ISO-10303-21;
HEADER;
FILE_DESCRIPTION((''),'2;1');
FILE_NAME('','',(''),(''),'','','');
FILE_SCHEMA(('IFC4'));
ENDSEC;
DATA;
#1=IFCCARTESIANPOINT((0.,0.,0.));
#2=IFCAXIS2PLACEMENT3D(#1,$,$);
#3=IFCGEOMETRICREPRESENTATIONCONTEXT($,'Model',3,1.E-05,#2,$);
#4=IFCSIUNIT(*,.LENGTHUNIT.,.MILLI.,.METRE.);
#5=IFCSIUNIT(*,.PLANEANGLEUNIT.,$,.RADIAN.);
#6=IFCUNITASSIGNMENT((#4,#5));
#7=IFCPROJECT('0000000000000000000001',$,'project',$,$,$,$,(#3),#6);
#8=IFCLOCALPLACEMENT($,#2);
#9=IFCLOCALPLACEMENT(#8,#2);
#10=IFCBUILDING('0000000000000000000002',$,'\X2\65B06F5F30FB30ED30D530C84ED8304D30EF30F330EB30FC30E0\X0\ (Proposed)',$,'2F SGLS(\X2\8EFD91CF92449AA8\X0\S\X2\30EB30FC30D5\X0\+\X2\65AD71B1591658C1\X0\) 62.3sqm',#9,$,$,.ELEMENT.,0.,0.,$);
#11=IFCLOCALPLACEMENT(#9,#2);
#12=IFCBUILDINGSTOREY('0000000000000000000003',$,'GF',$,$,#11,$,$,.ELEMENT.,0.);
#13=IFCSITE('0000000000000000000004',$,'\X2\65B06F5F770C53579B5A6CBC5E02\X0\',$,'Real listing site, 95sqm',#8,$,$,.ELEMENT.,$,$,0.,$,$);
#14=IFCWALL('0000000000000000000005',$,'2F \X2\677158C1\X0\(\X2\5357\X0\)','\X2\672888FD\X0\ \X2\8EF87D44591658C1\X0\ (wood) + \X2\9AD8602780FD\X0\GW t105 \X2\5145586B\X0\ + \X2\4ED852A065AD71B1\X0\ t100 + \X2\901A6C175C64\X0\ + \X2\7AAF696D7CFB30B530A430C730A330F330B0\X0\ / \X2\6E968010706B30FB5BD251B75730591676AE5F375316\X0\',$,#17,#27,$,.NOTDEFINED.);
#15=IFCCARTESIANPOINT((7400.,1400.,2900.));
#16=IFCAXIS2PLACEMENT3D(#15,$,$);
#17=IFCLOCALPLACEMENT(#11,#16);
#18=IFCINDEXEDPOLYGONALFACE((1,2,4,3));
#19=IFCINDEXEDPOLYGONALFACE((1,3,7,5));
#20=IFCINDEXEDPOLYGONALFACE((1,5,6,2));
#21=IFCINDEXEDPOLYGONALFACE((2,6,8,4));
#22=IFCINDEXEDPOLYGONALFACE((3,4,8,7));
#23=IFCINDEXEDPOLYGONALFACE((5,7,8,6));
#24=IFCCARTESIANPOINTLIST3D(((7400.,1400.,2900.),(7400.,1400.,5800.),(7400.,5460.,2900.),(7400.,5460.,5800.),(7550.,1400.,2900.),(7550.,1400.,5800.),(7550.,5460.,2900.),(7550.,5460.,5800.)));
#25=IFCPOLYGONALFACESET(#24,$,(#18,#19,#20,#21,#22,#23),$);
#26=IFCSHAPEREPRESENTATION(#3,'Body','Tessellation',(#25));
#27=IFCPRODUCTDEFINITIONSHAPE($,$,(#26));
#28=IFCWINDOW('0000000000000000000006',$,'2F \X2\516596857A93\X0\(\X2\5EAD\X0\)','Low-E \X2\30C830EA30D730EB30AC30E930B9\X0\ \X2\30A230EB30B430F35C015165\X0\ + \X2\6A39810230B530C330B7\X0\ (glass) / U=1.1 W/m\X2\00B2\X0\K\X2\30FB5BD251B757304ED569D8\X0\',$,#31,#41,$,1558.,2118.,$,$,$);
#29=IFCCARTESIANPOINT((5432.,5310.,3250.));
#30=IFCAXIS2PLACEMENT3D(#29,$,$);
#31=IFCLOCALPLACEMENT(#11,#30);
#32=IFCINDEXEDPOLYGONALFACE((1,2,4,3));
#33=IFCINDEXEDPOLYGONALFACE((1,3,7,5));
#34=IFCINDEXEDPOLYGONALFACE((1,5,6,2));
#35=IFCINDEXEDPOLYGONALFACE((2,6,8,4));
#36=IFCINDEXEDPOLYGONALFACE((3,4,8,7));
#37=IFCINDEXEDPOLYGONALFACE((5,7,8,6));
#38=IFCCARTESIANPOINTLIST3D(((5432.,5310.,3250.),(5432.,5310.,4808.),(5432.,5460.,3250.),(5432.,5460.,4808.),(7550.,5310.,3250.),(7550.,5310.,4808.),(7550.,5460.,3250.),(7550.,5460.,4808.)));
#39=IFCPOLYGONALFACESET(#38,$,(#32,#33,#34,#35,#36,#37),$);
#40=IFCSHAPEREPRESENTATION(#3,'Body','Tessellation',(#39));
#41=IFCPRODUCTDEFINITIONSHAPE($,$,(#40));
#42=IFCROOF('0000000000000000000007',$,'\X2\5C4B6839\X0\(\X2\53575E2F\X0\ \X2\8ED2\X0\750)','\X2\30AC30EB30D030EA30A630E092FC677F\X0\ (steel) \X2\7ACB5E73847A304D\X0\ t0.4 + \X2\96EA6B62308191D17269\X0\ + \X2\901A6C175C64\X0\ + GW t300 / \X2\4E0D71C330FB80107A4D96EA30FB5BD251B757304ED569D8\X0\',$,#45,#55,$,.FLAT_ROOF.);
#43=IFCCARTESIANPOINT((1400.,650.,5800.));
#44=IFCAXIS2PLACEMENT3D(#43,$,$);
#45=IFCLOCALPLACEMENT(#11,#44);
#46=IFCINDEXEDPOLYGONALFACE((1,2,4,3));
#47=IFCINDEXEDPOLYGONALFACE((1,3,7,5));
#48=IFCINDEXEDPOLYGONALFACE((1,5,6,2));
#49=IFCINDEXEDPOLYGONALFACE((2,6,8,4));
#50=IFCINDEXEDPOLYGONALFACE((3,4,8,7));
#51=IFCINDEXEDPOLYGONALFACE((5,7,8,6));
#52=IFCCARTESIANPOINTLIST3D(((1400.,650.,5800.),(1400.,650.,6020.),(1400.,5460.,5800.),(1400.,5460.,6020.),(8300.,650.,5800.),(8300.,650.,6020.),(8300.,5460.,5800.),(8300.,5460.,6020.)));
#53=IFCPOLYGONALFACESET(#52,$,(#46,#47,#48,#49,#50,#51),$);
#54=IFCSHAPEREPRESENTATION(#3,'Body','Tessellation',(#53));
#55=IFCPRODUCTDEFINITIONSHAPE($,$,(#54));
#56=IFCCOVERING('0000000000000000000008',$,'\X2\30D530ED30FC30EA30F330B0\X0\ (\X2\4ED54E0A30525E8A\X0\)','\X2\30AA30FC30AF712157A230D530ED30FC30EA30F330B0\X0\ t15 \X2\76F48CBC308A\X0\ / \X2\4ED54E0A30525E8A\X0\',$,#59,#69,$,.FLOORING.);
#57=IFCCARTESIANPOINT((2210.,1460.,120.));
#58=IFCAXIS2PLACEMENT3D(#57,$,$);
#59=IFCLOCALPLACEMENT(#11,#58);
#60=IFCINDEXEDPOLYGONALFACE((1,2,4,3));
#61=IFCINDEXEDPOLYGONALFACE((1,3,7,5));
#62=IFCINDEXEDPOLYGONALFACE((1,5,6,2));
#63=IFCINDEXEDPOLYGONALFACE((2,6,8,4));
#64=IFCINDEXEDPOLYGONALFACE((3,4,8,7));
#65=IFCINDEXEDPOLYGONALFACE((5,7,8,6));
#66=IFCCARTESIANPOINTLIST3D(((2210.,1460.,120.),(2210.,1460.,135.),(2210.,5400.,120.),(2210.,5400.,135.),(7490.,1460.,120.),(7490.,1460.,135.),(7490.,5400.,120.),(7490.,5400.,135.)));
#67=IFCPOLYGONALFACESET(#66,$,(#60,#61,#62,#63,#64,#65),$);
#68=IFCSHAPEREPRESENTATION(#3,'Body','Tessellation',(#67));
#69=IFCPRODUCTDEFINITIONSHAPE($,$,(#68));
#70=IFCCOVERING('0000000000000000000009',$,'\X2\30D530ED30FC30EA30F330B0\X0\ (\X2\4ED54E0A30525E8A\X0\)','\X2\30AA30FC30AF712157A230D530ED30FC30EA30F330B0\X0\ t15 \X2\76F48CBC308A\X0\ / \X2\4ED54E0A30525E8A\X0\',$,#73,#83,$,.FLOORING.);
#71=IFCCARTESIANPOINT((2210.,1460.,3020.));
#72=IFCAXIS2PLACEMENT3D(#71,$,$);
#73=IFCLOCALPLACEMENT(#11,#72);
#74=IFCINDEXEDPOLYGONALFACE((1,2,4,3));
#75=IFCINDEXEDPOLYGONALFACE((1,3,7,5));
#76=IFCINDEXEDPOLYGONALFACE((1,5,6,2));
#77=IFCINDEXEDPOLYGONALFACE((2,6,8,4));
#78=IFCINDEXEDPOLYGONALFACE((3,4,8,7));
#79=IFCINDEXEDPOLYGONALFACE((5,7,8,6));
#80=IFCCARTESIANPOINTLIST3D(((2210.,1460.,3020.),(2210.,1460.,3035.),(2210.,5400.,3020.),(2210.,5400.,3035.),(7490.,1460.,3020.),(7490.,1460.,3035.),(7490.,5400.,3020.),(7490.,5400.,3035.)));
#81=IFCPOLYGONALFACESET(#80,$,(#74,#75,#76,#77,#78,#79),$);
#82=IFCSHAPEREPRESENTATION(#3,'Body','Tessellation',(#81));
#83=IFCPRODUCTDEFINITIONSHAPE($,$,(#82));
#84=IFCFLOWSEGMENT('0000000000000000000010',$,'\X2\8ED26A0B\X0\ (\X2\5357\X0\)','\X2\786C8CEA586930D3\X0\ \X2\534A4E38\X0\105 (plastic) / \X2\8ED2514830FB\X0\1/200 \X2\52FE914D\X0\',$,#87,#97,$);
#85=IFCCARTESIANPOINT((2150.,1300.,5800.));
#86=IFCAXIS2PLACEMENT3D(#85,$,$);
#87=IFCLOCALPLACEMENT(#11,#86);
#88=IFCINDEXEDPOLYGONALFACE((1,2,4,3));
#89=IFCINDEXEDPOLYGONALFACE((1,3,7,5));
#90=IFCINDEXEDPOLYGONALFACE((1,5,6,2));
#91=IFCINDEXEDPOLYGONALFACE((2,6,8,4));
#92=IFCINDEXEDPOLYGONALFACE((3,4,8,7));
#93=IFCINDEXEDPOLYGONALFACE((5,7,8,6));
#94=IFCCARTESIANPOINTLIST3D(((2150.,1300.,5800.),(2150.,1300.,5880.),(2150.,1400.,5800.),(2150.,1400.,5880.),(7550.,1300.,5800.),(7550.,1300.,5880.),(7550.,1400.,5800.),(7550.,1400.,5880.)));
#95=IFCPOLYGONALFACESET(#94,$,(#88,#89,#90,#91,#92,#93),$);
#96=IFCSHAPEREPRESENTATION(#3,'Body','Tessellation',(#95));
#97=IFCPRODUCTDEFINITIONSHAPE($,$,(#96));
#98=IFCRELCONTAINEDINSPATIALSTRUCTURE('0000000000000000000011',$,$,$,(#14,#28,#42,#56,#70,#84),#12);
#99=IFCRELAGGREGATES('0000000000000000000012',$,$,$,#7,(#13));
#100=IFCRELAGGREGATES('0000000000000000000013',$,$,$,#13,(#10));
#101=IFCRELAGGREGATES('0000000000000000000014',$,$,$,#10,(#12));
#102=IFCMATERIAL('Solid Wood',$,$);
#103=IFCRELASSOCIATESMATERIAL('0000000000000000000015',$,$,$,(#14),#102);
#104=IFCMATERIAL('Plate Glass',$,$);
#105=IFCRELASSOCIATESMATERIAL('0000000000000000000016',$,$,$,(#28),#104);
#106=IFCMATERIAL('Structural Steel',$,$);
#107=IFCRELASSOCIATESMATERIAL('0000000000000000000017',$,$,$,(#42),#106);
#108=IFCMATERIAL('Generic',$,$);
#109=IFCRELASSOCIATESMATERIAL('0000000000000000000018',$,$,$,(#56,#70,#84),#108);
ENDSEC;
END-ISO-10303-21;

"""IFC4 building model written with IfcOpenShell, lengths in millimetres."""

from ifc_helpers import new_model, si_unit, frame, frame_2d, origin, place, context, project, spatial, rectangle, extrude, material, element, fill, save


model = new_model("IFC4")

# Units and contexts
model_context = context("Model", 3, precision=1e-05, world=origin())
ifc_project = project(units=[si_unit("LENGTHUNIT", "METRE", prefix="MILLI"), si_unit("PLANEANGLEUNIT", "RADIAN")], contexts=[model_context])

# Site, building, storey
site_placement = place(None, origin())
site = spatial("IfcSite", under=ifc_project, at=site_placement, Name="新潟県南魚沼市", ObjectType="Real listing site, 95sqm", CompositionType="ELEMENT", RefElevation=0.0)
building_placement = place(site_placement, origin())
building = spatial("IfcBuilding", under=site, at=building_placement, Name="新潟・ロフト付きワンルーム (Proposed)", ObjectType="2F SGLS(軽量鉄骨Sルーフ+断熱外壁) 62.3sqm", CompositionType="ELEMENT", ElevationOfRefHeight=0.0, ElevationOfTerrain=0.0)
storey_placement = place(building_placement, origin())
storey = spatial("IfcBuildingStorey", under=building, at=storey_placement, Name="GF", CompositionType="ELEMENT", Elevation=0.0)

# Shared definitions
ifc_material_1 = material(Name="Solid Wood")

# Shared definitions
ifc_material_2 = material(Name="Plate Glass")

# Wall, opening, window
wall_1_placement = place(storey_placement, frame((7400.0, 1400.0, 2900.0)))
wall_1 = element("IfcWall", 1, at=wall_1_placement, inside=storey, material=ifc_material_1, Name="2F 東壁(南)", Description="木製 軸組外壁 (wood) + 高性能GW t105 充填 + 付加断熱 t100 + 通気層 + 窯業系サイディング / 準耐火・寒冷地外皮強化", PredefinedType="NOTDEFINED", context=model_context, shape_type="SweptSolid", body=[
    extrude(rectangle(XDim=150.0, YDim=4060.0, at=frame_2d((75.0, 2030.0))), frame((7400.0, 1400.0, 2900.0)), (0.0, 0.0, 1.0), 2900.0),
])
opening_1_placement = place(storey_placement, frame((5432.0, 5310.0, 3250.0)))
opening_1 = element("IfcOpeningElement", 2, at=opening_1_placement, cuts=wall_1, PredefinedType="NOTDEFINED", context=model_context, shape_type="SweptSolid", body=[
    extrude(rectangle(XDim=2118.0, YDim=150.0, at=frame_2d((1059.0, 75.0))), frame((5432.0, 5310.0, 3250.0)), (0.0, 0.0, 1.0), 1558.0),
])
window_1_placement = place(storey_placement, frame((5432.0, 5310.0, 3250.0)))
window_1 = element("IfcWindow", 3, at=window_1_placement, inside=storey, material=ifc_material_2, Name="2F 入隅窓(庭)", Description="Low-E トリプルガラス アルゴン封入 + 樹脂サッシ (glass) / U=1.1 W/m²K・寒冷地仕様", OverallHeight=1558.0, OverallWidth=2118.0, context=model_context, shape_type="SweptSolid", body=[
    extrude(rectangle(XDim=2118.0, YDim=150.0, at=frame_2d((1059.0, 75.0))), frame((5432.0, 5310.0, 3250.0)), (0.0, 0.0, 1.0), 1558.0),
])
fill(opening_1, window_1)

# Roof
ifc_material_3 = material(Name="Structural Steel")
for number, where, name in (
    (4, (1400.0, 650.0, 5800.0), "屋根(南帯 軒750)"),
):
    element("IfcRoof", number, at=place(storey_placement, frame(where)), inside=storey, material=ifc_material_3, Name=name, Description="ガルバリウム鋼板 (steel) 立平葺き t0.4 + 雪止め金物 + 通気層 + GW t300 / 不燃・耐積雪・寒冷地仕様", PredefinedType="FLAT_ROOF", context=model_context, shape_type="SweptSolid", body=[
        extrude(rectangle(XDim=6900.0, YDim=4810.0, at=frame_2d((3450.0, 2405.0))), frame((1400.0, 650.0, 5800.0)), (0.0, 0.0, 1.0), 220.0),
    ])

# Coverings
ifc_material_4 = material(Name="Generic")
covering_1_placement = place(storey_placement, frame((2210.0, 1460.0, 120.0)))
element("IfcCovering", 5, at=covering_1_placement, inside=storey, material=ifc_material_4, Name="フローリング (仕上げ床)", Description="オーク無垢フローリング t15 直貼り / 仕上げ床", PredefinedType="FLOORING", context=model_context, shape_type="SweptSolid", body=[
    extrude(rectangle(XDim=5280.0, YDim=3940.0, at=frame_2d((2640.0, 1970.0))), frame((2210.0, 1460.0, 120.0)), (0.0, 0.0, 1.0), 15.0),
])
covering_2_placement = place(storey_placement, frame((2210.0, 1460.0, 3020.0)))
element("IfcCovering", 6, at=covering_2_placement, inside=storey, material=ifc_material_4, Name="フローリング (仕上げ床)", Description="オーク無垢フローリング t15 直貼り / 仕上げ床", PredefinedType="FLOORING", context=model_context, shape_type="SweptSolid", body=[
    extrude(rectangle(XDim=5280.0, YDim=3940.0, at=frame_2d((2640.0, 1970.0))), frame((2210.0, 1460.0, 3020.0)), (0.0, 0.0, 1.0), 15.0),
])

# Flow segment
flow_segment_placement = place(storey_placement, frame((2150.0, 1300.0, 5800.0)))
element("IfcFlowSegment", 7, at=flow_segment_placement, inside=storey, material=ifc_material_4, Name="軒樋 (南)", Description="硬質塩ビ 半丸105 (plastic) / 軒先・1/200 勾配", context=model_context, shape_type="SweptSolid", body=[
    extrude(rectangle(XDim=5400.0, YDim=100.0, at=frame_2d((2700.0, 50.0))), frame((2150.0, 1300.0, 5800.0)), (0.0, 0.0, 1.0), 80.0),
])

save(model, "model.ifc")
